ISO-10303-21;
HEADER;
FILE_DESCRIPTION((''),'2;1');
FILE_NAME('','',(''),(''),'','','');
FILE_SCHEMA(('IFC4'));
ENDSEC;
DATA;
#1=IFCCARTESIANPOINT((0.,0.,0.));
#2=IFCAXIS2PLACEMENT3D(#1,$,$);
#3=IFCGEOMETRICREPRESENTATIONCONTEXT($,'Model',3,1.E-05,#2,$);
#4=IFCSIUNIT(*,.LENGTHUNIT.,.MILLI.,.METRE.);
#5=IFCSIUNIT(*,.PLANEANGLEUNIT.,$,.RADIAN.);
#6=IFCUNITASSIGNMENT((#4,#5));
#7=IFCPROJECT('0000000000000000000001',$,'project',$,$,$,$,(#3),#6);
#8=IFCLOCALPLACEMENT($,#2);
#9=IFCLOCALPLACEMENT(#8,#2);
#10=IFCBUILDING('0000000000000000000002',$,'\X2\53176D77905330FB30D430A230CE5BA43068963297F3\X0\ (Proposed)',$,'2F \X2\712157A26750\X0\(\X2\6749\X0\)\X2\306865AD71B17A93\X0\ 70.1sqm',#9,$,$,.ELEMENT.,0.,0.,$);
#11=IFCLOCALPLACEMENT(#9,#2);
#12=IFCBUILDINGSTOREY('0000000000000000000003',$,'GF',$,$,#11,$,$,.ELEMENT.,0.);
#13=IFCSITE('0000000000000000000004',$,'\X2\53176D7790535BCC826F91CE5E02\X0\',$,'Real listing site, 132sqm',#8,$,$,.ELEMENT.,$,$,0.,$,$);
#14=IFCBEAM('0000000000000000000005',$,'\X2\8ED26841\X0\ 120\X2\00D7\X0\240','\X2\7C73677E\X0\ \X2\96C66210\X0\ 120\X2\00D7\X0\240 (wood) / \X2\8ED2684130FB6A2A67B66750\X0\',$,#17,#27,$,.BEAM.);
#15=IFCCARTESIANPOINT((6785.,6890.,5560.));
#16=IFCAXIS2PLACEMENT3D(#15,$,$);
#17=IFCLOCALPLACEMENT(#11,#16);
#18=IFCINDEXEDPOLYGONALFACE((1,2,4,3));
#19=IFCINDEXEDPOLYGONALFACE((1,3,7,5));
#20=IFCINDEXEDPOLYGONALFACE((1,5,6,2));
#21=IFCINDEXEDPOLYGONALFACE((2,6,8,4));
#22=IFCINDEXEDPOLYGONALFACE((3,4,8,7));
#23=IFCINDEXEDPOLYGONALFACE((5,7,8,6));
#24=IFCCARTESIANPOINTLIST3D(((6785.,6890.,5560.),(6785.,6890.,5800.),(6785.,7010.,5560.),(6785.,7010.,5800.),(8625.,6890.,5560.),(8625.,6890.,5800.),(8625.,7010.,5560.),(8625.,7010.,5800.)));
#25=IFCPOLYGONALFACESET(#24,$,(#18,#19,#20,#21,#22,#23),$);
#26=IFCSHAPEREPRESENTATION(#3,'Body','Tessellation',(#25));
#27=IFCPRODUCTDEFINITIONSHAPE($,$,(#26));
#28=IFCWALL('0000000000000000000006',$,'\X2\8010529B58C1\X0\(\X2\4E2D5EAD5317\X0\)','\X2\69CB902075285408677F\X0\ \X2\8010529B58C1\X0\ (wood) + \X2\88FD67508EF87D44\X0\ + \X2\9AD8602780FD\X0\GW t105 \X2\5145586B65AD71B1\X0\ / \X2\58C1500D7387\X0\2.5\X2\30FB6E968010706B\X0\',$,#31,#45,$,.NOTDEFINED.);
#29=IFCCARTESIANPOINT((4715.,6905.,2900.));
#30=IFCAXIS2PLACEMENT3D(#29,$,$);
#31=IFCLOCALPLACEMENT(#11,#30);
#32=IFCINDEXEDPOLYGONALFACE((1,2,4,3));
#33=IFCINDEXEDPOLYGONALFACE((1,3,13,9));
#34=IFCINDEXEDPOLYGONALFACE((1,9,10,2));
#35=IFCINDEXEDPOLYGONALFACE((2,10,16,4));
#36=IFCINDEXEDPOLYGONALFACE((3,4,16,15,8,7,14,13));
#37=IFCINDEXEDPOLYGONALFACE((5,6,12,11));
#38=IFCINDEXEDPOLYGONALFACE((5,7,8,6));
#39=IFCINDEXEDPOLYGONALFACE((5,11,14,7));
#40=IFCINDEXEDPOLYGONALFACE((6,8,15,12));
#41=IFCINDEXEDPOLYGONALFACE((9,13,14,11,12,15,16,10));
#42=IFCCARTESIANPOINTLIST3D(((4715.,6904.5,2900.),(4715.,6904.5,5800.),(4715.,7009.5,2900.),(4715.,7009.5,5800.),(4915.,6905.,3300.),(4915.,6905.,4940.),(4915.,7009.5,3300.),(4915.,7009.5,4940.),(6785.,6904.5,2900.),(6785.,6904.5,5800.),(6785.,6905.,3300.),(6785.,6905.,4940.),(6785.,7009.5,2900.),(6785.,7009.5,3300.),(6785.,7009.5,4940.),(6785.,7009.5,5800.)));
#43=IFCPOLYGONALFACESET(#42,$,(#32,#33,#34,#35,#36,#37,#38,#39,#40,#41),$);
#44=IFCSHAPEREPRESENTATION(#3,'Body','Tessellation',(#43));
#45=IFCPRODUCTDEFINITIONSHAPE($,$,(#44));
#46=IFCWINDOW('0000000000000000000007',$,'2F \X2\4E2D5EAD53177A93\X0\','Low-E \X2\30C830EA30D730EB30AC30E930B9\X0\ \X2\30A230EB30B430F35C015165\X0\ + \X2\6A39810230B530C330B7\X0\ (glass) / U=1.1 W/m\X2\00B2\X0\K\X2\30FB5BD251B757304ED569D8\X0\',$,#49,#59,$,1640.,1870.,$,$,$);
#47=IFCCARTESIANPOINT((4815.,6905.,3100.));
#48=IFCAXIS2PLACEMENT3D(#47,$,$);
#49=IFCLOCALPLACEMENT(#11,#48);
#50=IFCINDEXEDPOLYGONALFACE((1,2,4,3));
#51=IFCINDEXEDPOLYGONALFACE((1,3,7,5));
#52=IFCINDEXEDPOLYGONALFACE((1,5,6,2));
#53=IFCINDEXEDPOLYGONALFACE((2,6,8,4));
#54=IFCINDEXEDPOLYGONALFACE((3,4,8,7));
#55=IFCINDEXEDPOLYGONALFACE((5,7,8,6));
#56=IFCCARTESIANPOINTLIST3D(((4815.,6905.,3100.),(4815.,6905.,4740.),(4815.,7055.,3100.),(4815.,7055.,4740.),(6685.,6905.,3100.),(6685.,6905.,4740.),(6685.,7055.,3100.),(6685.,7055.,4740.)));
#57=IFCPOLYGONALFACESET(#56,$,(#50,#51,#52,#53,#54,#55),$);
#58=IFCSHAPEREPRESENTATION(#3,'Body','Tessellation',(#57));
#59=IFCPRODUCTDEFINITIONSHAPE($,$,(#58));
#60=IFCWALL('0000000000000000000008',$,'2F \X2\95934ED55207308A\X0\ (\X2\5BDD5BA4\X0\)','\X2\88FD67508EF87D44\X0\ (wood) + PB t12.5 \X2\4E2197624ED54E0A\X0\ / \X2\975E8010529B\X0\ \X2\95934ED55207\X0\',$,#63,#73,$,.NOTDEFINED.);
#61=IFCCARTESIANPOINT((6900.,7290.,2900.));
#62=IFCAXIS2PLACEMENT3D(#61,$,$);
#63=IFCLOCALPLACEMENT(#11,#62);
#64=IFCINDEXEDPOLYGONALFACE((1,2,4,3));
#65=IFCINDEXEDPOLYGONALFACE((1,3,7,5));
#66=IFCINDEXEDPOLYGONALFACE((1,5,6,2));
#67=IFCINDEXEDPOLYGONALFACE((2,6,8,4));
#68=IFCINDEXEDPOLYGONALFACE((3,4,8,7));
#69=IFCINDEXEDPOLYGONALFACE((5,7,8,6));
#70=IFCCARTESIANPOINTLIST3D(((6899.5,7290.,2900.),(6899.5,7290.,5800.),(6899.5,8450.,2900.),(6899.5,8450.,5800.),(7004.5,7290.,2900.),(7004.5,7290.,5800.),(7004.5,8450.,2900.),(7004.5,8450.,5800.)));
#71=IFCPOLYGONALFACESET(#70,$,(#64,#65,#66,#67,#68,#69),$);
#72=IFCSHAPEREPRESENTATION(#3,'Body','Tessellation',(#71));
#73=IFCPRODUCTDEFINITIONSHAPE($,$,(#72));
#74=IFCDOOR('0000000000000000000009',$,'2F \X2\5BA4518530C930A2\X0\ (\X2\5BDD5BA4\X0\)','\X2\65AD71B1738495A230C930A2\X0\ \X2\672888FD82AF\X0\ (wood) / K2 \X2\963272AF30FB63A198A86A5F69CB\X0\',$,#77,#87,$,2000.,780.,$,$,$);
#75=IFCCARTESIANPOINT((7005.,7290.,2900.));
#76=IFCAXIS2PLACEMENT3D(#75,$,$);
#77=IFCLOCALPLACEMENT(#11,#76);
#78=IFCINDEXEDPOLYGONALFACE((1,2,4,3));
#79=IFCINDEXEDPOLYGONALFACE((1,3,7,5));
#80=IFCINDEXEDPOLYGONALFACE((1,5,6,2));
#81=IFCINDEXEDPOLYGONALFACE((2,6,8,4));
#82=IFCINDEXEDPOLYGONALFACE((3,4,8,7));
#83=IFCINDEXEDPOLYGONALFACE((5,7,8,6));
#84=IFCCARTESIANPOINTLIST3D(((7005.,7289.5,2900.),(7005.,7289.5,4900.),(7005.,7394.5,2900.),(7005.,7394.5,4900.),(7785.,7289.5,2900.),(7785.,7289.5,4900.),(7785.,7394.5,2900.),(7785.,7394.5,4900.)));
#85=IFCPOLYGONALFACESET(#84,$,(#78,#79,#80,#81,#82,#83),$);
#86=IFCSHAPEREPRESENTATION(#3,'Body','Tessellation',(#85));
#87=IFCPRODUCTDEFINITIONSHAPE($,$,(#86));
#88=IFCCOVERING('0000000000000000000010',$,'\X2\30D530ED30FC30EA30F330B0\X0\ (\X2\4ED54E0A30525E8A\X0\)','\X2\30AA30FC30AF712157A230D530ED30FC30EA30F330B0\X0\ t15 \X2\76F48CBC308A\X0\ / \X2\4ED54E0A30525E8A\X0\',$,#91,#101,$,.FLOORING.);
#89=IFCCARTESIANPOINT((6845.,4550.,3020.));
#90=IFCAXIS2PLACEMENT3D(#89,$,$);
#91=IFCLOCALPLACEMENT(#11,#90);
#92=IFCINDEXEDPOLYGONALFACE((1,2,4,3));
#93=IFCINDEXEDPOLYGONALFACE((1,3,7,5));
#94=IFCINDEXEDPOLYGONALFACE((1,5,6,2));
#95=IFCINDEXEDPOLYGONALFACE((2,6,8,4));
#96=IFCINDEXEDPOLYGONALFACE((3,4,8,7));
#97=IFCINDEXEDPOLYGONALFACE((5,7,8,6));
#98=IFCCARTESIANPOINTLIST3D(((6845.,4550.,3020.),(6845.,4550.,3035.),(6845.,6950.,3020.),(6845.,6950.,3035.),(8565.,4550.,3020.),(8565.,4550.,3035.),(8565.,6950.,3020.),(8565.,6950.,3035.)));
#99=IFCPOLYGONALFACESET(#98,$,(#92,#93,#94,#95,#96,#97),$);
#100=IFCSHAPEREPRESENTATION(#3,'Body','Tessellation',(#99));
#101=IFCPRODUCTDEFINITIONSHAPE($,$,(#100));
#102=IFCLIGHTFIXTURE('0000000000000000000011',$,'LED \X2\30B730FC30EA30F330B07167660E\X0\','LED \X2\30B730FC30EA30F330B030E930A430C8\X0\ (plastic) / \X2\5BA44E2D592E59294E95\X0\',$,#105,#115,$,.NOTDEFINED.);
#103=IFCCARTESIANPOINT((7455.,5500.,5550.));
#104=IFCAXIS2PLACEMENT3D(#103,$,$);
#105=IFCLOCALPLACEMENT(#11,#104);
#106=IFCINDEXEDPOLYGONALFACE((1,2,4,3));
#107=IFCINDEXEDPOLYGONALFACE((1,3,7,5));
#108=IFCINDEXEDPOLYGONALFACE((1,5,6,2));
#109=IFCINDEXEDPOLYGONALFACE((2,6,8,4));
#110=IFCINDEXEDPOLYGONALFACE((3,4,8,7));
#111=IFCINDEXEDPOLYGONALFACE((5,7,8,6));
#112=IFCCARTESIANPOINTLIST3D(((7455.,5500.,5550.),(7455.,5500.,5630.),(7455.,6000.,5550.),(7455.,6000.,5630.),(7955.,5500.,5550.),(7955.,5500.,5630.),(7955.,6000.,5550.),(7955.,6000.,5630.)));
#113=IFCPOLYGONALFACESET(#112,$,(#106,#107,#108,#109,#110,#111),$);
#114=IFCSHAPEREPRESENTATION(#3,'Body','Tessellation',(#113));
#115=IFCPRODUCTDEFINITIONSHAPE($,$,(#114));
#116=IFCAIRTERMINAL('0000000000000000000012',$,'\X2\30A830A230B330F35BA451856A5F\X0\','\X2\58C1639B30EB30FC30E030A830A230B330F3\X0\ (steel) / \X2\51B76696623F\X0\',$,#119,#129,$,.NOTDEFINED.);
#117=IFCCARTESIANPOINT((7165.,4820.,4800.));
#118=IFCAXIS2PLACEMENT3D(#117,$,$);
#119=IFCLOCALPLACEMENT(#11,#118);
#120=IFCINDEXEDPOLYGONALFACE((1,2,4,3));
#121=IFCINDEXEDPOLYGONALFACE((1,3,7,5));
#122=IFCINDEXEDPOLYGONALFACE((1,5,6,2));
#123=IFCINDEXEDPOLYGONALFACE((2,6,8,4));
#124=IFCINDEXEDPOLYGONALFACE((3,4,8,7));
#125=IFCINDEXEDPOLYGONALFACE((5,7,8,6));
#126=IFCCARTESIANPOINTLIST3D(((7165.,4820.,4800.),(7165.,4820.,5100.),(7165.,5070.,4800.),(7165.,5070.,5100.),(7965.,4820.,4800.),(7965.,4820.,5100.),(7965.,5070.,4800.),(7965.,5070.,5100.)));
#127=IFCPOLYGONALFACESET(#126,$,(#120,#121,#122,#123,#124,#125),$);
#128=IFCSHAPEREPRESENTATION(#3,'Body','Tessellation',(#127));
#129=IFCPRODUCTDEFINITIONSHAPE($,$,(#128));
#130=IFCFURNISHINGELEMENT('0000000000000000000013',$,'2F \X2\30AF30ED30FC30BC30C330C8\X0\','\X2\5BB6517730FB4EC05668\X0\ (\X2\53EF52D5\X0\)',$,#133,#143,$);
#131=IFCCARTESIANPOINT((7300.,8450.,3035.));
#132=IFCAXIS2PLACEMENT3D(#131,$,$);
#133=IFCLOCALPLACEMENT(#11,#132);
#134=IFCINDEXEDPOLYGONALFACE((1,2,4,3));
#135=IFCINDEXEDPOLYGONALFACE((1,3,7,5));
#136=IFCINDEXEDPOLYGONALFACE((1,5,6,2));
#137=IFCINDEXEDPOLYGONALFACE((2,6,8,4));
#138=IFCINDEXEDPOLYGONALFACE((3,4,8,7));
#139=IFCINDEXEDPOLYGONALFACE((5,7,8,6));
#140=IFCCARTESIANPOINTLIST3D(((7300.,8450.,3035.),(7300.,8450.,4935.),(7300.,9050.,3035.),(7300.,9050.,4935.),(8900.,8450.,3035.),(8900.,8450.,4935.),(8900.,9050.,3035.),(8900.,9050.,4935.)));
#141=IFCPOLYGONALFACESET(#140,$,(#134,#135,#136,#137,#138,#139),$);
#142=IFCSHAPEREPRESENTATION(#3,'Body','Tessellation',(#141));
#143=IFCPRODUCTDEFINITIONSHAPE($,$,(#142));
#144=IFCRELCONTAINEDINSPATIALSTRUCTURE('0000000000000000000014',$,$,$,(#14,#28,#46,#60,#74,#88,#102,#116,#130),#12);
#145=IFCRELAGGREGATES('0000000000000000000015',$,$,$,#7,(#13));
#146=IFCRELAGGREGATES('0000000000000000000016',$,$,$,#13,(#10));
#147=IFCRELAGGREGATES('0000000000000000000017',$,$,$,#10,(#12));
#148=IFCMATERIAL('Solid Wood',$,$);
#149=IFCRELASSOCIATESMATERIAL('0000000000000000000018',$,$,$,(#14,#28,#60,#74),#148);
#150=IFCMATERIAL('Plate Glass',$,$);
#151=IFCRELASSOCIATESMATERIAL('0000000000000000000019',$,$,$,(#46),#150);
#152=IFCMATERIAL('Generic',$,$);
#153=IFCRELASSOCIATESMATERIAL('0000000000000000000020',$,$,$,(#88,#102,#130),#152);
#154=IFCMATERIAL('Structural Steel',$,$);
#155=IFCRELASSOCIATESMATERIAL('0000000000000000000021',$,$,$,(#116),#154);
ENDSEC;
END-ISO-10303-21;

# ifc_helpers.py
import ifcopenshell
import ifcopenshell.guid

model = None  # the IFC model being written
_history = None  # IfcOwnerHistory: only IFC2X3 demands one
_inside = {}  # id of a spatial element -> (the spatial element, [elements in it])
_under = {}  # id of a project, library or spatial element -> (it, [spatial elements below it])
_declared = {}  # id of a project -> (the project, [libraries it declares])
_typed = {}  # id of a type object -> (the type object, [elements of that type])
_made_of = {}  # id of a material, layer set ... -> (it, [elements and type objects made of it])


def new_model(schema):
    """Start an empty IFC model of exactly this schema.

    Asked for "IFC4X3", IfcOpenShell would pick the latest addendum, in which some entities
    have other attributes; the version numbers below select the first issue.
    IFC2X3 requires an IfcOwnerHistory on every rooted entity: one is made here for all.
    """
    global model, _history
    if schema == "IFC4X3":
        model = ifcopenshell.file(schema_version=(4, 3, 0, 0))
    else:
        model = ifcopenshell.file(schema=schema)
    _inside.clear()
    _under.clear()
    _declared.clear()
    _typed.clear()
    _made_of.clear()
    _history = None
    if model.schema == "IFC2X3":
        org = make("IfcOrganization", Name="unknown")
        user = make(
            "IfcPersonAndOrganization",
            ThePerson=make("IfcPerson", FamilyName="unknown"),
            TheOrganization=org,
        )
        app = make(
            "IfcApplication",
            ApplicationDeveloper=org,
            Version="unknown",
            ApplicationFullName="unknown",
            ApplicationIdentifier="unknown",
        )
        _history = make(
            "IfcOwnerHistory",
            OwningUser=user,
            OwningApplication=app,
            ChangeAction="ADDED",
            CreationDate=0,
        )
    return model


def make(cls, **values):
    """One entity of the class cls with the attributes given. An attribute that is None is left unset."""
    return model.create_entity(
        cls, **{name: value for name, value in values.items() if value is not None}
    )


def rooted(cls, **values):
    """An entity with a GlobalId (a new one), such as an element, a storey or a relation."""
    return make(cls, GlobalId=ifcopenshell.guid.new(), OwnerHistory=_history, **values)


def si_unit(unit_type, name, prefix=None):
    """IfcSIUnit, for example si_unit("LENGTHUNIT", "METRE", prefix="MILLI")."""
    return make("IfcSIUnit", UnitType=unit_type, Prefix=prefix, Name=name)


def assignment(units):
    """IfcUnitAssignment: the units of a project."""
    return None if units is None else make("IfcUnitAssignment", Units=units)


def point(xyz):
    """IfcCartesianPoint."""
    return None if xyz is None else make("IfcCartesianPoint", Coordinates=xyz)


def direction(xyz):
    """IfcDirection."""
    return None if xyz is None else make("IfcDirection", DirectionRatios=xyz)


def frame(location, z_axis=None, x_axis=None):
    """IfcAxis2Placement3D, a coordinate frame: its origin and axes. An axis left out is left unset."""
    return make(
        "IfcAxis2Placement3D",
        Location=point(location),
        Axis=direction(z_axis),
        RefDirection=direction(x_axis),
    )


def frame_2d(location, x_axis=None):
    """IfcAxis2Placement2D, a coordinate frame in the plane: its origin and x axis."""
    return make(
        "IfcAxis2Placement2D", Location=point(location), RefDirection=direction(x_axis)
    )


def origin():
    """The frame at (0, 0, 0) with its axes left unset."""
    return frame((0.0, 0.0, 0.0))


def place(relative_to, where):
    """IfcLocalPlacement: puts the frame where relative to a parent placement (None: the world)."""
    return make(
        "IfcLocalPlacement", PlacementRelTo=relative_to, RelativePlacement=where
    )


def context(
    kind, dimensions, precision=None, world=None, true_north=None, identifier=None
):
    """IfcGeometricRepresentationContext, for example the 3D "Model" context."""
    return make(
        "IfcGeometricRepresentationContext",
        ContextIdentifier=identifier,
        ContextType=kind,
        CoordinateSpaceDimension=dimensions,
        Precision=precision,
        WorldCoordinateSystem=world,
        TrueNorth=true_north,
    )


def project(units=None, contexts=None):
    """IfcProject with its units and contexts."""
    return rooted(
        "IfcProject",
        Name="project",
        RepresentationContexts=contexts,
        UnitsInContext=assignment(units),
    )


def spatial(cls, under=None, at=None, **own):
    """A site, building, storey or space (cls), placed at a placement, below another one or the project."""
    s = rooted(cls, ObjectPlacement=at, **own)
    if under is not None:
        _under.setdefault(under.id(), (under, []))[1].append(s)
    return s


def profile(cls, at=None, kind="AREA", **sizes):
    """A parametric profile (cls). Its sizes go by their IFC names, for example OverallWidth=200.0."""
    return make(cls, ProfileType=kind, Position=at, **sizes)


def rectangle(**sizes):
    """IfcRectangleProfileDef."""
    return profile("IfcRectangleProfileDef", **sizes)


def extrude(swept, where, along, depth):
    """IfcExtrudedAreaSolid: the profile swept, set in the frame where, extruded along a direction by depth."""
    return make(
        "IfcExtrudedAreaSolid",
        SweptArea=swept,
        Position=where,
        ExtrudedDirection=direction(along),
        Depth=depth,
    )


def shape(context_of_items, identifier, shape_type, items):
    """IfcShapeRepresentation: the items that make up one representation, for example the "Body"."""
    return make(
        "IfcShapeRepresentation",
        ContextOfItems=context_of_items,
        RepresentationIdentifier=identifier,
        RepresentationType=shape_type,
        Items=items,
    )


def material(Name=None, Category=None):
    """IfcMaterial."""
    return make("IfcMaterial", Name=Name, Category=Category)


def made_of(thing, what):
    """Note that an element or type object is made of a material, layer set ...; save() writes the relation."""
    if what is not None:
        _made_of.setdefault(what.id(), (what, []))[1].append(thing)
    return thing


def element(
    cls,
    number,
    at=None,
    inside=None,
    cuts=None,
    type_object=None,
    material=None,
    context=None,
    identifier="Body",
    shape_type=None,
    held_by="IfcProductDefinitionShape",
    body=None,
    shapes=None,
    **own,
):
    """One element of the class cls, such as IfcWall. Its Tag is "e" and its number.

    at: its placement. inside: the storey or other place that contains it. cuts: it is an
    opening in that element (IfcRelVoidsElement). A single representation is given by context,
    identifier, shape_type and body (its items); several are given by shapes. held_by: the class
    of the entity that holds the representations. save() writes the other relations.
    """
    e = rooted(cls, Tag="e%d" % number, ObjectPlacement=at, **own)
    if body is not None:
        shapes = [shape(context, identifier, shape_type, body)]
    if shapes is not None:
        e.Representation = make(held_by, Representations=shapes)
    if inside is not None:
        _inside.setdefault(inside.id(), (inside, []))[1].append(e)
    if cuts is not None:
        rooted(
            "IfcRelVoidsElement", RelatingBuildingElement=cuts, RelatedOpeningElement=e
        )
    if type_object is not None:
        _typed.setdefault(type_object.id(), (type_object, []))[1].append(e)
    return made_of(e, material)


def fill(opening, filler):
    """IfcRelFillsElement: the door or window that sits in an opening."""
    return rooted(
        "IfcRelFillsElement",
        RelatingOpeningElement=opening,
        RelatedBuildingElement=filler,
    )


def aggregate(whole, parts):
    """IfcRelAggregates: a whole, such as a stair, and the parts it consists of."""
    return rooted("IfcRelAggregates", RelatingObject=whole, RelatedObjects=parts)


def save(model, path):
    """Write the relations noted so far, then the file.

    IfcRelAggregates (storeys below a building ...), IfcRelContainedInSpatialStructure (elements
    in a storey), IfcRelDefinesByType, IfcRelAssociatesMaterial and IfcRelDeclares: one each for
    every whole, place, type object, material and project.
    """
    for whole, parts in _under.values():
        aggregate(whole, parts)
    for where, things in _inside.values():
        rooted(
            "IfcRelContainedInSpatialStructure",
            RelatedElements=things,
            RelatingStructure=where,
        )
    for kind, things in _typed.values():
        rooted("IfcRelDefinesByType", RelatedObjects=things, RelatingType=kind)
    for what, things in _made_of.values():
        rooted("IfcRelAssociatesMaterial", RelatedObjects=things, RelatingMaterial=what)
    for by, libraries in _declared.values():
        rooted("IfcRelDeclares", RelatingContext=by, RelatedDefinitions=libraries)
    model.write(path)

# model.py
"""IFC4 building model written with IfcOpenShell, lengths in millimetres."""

from ifc_helpers import new_model, si_unit, frame, frame_2d, origin, place, context, project, spatial, rectangle, extrude, material, element, fill, save


model = new_model("IFC4")

# Units and contexts
model_context = context("Model", 3, precision=1e-05, world=origin())
ifc_project = project(units=[si_unit("LENGTHUNIT", "METRE", prefix="MILLI"), si_unit("PLANEANGLEUNIT", "RADIAN")], contexts=[model_context])

# Site, building, storey
site_placement = place(None, origin())
site = spatial("IfcSite", under=ifc_project, at=site_placement, Name="北海道富良野市", ObjectType="Real listing site, 132sqm", CompositionType="ELEMENT", RefElevation=0.0)
building_placement = place(site_placement, origin())
building = spatial("IfcBuilding", under=site, at=building_placement, Name="北海道・ピアノ室と防音 (Proposed)", ObjectType="2F 無垢材(杉)と断熱窓 70.1sqm", CompositionType="ELEMENT", ElevationOfRefHeight=0.0, ElevationOfTerrain=0.0)
storey_placement = place(building_placement, origin())
storey = spatial("IfcBuildingStorey", under=building, at=storey_placement, Name="GF", CompositionType="ELEMENT", Elevation=0.0)

# Shared definitions
ifc_material_1 = material(Name="Solid Wood")

# Beam
beam_1_placement = place(storey_placement, frame((6785.0, 6890.0, 5560.0)))
element("IfcBeam", 1, at=beam_1_placement, inside=storey, material=ifc_material_1, Name="軒桁 120×240", Description="米松 集成 120×240 (wood) / 軒桁・横架材", PredefinedType="BEAM", context=model_context, shape_type="SweptSolid", body=[
    extrude(rectangle(XDim=1840.0, YDim=120.0, at=frame_2d((920.0, 60.0))), frame((6785.0, 6890.0, 5560.0)), (0.0, 0.0, 1.0), 240.0),
])

# Wall, opening, window
wall_1_placement = place(storey_placement, frame((4715.0, 6905.0, 2900.0)))
wall_1 = element("IfcWall", 2, at=wall_1_placement, inside=storey, material=ifc_material_1, Name="耐力壁(中庭北)", Description="構造用合板 耐力壁 (wood) + 製材軸組 + 高性能GW t105 充填断熱 / 壁倍率2.5・準耐火", PredefinedType="NOTDEFINED", context=model_context, shape_type="SweptSolid", body=[
    extrude(rectangle(XDim=2070.0, YDim=105.0, at=frame_2d((1035.0, 52.0))), frame((4715.0, 6905.0, 2900.0)), (0.0, 0.0, 1.0), 2900.0),
])
opening_placement = place(storey_placement, frame((4815.0, 6905.0, 3100.0)))
opening = element("IfcOpeningElement", 3, at=opening_placement, cuts=wall_1, PredefinedType="NOTDEFINED", context=model_context, shape_type="SweptSolid", body=[
    extrude(rectangle(XDim=1870.0, YDim=150.0, at=frame_2d((935.0, 75.0))), frame((4815.0, 6905.0, 3100.0)), (0.0, 0.0, 1.0), 1640.0),
])
ifc_material_2 = material(Name="Plate Glass")
window_placement = place(storey_placement, frame((4815.0, 6905.0, 3100.0)))
window = element("IfcWindow", 4, at=window_placement, inside=storey, material=ifc_material_2, Name="2F 中庭北窓", Description="Low-E トリプルガラス アルゴン封入 + 樹脂サッシ (glass) / U=1.1 W/m²K・寒冷地仕様", OverallHeight=1640.0, OverallWidth=1870.0, context=model_context, shape_type="SweptSolid", body=[
    extrude(rectangle(XDim=1870.0, YDim=150.0, at=frame_2d((935.0, 75.0))), frame((4815.0, 6905.0, 3100.0)), (0.0, 0.0, 1.0), 1640.0),
])
fill(opening, window)

# Wall
wall_2_placement = place(storey_placement, frame((6900.0, 7290.0, 2900.0)))
element("IfcWall", 5, at=wall_2_placement, inside=storey, material=ifc_material_1, Name="2F 間仕切り (寝室)", Description="製材軸組 (wood) + PB t12.5 両面仕上 / 非耐力 間仕切", PredefinedType="NOTDEFINED", context=model_context, shape_type="SweptSolid", body=[
    extrude(rectangle(XDim=105.0, YDim=1160.0, at=frame_2d((52.0, 580.0))), frame((6900.0, 7290.0, 2900.0)), (0.0, 0.0, 1.0), 2900.0),
])

# Door
door_placement = place(storey_placement, frame((7005.0, 7290.0, 2900.0)))
element("IfcDoor", 6, at=door_placement, inside=storey, material=ifc_material_1, Name="2F 室内ドア (寝室)", Description="断熱玄関ドア 木製芯 (wood) / K2 防犯・採風機構", OverallHeight=2000.0, OverallWidth=780.0, context=model_context, shape_type="SweptSolid", body=[
    extrude(rectangle(XDim=780.0, YDim=105.0, at=frame_2d((390.0, 52.0))), frame((7005.0, 7290.0, 2900.0)), (0.0, 0.0, 1.0), 2000.0),
])

# Covering
ifc_material_3 = material(Name="Generic")
covering_placement = place(storey_placement, frame((6845.0, 4550.0, 3020.0)))
element("IfcCovering", 7, at=covering_placement, inside=storey, material=ifc_material_3, Name="フローリング (仕上げ床)", Description="オーク無垢フローリング t15 直貼り / 仕上げ床", PredefinedType="FLOORING", context=model_context, shape_type="SweptSolid", body=[
    extrude(rectangle(XDim=1720.0, YDim=2400.0, at=frame_2d((860.0, 1200.0))), frame((6845.0, 4550.0, 3020.0)), (0.0, 0.0, 1.0), 15.0),
])

# Light fixture
light_fixture_placement = place(storey_placement, frame((7455.0, 5500.0, 5550.0)))
element("IfcLightFixture", 8, at=light_fixture_placement, inside=storey, material=ifc_material_3, Name="LED シーリング照明", Description="LED シーリングライト (plastic) / 室中央天井", PredefinedType="NOTDEFINED", context=model_context, shape_type="SweptSolid", body=[
    extrude(rectangle(XDim=500.0, YDim=500.0, at=frame_2d((250.0, 250.0))), frame((7455.0, 5500.0, 5550.0)), (0.0, 0.0, 1.0), 80.0),
])

# Air terminal
ifc_material_4 = material(Name="Structural Steel")
air_terminal_placement = place(storey_placement, frame((7165.0, 4820.0, 4800.0)))
element("IfcAirTerminal", 9, at=air_terminal_placement, inside=storey, material=ifc_material_4, Name="エアコン室内機", Description="壁掛ルームエアコン (steel) / 冷暖房", PredefinedType="NOTDEFINED", context=model_context, shape_type="SweptSolid", body=[
    extrude(rectangle(XDim=800.0, YDim=250.0, at=frame_2d((400.0, 125.0))), frame((7165.0, 4820.0, 4800.0)), (0.0, 0.0, 1.0), 300.0),
])

# Furnishing element
furnishing_placement = place(storey_placement, frame((7300.0, 8450.0, 3035.0)))
element("IfcFurnishingElement", 10, at=furnishing_placement, inside=storey, material=ifc_material_3, Name="2F クローゼット", Description="家具・什器 (可動)", context=model_context, shape_type="SweptSolid", body=[
    extrude(rectangle(XDim=1600.0, YDim=600.0, at=frame_2d((800.0, 300.0))), frame((7300.0, 8450.0, 3035.0)), (0.0, 0.0, 1.0), 1900.0),
])

save(model, "model.ifc")
